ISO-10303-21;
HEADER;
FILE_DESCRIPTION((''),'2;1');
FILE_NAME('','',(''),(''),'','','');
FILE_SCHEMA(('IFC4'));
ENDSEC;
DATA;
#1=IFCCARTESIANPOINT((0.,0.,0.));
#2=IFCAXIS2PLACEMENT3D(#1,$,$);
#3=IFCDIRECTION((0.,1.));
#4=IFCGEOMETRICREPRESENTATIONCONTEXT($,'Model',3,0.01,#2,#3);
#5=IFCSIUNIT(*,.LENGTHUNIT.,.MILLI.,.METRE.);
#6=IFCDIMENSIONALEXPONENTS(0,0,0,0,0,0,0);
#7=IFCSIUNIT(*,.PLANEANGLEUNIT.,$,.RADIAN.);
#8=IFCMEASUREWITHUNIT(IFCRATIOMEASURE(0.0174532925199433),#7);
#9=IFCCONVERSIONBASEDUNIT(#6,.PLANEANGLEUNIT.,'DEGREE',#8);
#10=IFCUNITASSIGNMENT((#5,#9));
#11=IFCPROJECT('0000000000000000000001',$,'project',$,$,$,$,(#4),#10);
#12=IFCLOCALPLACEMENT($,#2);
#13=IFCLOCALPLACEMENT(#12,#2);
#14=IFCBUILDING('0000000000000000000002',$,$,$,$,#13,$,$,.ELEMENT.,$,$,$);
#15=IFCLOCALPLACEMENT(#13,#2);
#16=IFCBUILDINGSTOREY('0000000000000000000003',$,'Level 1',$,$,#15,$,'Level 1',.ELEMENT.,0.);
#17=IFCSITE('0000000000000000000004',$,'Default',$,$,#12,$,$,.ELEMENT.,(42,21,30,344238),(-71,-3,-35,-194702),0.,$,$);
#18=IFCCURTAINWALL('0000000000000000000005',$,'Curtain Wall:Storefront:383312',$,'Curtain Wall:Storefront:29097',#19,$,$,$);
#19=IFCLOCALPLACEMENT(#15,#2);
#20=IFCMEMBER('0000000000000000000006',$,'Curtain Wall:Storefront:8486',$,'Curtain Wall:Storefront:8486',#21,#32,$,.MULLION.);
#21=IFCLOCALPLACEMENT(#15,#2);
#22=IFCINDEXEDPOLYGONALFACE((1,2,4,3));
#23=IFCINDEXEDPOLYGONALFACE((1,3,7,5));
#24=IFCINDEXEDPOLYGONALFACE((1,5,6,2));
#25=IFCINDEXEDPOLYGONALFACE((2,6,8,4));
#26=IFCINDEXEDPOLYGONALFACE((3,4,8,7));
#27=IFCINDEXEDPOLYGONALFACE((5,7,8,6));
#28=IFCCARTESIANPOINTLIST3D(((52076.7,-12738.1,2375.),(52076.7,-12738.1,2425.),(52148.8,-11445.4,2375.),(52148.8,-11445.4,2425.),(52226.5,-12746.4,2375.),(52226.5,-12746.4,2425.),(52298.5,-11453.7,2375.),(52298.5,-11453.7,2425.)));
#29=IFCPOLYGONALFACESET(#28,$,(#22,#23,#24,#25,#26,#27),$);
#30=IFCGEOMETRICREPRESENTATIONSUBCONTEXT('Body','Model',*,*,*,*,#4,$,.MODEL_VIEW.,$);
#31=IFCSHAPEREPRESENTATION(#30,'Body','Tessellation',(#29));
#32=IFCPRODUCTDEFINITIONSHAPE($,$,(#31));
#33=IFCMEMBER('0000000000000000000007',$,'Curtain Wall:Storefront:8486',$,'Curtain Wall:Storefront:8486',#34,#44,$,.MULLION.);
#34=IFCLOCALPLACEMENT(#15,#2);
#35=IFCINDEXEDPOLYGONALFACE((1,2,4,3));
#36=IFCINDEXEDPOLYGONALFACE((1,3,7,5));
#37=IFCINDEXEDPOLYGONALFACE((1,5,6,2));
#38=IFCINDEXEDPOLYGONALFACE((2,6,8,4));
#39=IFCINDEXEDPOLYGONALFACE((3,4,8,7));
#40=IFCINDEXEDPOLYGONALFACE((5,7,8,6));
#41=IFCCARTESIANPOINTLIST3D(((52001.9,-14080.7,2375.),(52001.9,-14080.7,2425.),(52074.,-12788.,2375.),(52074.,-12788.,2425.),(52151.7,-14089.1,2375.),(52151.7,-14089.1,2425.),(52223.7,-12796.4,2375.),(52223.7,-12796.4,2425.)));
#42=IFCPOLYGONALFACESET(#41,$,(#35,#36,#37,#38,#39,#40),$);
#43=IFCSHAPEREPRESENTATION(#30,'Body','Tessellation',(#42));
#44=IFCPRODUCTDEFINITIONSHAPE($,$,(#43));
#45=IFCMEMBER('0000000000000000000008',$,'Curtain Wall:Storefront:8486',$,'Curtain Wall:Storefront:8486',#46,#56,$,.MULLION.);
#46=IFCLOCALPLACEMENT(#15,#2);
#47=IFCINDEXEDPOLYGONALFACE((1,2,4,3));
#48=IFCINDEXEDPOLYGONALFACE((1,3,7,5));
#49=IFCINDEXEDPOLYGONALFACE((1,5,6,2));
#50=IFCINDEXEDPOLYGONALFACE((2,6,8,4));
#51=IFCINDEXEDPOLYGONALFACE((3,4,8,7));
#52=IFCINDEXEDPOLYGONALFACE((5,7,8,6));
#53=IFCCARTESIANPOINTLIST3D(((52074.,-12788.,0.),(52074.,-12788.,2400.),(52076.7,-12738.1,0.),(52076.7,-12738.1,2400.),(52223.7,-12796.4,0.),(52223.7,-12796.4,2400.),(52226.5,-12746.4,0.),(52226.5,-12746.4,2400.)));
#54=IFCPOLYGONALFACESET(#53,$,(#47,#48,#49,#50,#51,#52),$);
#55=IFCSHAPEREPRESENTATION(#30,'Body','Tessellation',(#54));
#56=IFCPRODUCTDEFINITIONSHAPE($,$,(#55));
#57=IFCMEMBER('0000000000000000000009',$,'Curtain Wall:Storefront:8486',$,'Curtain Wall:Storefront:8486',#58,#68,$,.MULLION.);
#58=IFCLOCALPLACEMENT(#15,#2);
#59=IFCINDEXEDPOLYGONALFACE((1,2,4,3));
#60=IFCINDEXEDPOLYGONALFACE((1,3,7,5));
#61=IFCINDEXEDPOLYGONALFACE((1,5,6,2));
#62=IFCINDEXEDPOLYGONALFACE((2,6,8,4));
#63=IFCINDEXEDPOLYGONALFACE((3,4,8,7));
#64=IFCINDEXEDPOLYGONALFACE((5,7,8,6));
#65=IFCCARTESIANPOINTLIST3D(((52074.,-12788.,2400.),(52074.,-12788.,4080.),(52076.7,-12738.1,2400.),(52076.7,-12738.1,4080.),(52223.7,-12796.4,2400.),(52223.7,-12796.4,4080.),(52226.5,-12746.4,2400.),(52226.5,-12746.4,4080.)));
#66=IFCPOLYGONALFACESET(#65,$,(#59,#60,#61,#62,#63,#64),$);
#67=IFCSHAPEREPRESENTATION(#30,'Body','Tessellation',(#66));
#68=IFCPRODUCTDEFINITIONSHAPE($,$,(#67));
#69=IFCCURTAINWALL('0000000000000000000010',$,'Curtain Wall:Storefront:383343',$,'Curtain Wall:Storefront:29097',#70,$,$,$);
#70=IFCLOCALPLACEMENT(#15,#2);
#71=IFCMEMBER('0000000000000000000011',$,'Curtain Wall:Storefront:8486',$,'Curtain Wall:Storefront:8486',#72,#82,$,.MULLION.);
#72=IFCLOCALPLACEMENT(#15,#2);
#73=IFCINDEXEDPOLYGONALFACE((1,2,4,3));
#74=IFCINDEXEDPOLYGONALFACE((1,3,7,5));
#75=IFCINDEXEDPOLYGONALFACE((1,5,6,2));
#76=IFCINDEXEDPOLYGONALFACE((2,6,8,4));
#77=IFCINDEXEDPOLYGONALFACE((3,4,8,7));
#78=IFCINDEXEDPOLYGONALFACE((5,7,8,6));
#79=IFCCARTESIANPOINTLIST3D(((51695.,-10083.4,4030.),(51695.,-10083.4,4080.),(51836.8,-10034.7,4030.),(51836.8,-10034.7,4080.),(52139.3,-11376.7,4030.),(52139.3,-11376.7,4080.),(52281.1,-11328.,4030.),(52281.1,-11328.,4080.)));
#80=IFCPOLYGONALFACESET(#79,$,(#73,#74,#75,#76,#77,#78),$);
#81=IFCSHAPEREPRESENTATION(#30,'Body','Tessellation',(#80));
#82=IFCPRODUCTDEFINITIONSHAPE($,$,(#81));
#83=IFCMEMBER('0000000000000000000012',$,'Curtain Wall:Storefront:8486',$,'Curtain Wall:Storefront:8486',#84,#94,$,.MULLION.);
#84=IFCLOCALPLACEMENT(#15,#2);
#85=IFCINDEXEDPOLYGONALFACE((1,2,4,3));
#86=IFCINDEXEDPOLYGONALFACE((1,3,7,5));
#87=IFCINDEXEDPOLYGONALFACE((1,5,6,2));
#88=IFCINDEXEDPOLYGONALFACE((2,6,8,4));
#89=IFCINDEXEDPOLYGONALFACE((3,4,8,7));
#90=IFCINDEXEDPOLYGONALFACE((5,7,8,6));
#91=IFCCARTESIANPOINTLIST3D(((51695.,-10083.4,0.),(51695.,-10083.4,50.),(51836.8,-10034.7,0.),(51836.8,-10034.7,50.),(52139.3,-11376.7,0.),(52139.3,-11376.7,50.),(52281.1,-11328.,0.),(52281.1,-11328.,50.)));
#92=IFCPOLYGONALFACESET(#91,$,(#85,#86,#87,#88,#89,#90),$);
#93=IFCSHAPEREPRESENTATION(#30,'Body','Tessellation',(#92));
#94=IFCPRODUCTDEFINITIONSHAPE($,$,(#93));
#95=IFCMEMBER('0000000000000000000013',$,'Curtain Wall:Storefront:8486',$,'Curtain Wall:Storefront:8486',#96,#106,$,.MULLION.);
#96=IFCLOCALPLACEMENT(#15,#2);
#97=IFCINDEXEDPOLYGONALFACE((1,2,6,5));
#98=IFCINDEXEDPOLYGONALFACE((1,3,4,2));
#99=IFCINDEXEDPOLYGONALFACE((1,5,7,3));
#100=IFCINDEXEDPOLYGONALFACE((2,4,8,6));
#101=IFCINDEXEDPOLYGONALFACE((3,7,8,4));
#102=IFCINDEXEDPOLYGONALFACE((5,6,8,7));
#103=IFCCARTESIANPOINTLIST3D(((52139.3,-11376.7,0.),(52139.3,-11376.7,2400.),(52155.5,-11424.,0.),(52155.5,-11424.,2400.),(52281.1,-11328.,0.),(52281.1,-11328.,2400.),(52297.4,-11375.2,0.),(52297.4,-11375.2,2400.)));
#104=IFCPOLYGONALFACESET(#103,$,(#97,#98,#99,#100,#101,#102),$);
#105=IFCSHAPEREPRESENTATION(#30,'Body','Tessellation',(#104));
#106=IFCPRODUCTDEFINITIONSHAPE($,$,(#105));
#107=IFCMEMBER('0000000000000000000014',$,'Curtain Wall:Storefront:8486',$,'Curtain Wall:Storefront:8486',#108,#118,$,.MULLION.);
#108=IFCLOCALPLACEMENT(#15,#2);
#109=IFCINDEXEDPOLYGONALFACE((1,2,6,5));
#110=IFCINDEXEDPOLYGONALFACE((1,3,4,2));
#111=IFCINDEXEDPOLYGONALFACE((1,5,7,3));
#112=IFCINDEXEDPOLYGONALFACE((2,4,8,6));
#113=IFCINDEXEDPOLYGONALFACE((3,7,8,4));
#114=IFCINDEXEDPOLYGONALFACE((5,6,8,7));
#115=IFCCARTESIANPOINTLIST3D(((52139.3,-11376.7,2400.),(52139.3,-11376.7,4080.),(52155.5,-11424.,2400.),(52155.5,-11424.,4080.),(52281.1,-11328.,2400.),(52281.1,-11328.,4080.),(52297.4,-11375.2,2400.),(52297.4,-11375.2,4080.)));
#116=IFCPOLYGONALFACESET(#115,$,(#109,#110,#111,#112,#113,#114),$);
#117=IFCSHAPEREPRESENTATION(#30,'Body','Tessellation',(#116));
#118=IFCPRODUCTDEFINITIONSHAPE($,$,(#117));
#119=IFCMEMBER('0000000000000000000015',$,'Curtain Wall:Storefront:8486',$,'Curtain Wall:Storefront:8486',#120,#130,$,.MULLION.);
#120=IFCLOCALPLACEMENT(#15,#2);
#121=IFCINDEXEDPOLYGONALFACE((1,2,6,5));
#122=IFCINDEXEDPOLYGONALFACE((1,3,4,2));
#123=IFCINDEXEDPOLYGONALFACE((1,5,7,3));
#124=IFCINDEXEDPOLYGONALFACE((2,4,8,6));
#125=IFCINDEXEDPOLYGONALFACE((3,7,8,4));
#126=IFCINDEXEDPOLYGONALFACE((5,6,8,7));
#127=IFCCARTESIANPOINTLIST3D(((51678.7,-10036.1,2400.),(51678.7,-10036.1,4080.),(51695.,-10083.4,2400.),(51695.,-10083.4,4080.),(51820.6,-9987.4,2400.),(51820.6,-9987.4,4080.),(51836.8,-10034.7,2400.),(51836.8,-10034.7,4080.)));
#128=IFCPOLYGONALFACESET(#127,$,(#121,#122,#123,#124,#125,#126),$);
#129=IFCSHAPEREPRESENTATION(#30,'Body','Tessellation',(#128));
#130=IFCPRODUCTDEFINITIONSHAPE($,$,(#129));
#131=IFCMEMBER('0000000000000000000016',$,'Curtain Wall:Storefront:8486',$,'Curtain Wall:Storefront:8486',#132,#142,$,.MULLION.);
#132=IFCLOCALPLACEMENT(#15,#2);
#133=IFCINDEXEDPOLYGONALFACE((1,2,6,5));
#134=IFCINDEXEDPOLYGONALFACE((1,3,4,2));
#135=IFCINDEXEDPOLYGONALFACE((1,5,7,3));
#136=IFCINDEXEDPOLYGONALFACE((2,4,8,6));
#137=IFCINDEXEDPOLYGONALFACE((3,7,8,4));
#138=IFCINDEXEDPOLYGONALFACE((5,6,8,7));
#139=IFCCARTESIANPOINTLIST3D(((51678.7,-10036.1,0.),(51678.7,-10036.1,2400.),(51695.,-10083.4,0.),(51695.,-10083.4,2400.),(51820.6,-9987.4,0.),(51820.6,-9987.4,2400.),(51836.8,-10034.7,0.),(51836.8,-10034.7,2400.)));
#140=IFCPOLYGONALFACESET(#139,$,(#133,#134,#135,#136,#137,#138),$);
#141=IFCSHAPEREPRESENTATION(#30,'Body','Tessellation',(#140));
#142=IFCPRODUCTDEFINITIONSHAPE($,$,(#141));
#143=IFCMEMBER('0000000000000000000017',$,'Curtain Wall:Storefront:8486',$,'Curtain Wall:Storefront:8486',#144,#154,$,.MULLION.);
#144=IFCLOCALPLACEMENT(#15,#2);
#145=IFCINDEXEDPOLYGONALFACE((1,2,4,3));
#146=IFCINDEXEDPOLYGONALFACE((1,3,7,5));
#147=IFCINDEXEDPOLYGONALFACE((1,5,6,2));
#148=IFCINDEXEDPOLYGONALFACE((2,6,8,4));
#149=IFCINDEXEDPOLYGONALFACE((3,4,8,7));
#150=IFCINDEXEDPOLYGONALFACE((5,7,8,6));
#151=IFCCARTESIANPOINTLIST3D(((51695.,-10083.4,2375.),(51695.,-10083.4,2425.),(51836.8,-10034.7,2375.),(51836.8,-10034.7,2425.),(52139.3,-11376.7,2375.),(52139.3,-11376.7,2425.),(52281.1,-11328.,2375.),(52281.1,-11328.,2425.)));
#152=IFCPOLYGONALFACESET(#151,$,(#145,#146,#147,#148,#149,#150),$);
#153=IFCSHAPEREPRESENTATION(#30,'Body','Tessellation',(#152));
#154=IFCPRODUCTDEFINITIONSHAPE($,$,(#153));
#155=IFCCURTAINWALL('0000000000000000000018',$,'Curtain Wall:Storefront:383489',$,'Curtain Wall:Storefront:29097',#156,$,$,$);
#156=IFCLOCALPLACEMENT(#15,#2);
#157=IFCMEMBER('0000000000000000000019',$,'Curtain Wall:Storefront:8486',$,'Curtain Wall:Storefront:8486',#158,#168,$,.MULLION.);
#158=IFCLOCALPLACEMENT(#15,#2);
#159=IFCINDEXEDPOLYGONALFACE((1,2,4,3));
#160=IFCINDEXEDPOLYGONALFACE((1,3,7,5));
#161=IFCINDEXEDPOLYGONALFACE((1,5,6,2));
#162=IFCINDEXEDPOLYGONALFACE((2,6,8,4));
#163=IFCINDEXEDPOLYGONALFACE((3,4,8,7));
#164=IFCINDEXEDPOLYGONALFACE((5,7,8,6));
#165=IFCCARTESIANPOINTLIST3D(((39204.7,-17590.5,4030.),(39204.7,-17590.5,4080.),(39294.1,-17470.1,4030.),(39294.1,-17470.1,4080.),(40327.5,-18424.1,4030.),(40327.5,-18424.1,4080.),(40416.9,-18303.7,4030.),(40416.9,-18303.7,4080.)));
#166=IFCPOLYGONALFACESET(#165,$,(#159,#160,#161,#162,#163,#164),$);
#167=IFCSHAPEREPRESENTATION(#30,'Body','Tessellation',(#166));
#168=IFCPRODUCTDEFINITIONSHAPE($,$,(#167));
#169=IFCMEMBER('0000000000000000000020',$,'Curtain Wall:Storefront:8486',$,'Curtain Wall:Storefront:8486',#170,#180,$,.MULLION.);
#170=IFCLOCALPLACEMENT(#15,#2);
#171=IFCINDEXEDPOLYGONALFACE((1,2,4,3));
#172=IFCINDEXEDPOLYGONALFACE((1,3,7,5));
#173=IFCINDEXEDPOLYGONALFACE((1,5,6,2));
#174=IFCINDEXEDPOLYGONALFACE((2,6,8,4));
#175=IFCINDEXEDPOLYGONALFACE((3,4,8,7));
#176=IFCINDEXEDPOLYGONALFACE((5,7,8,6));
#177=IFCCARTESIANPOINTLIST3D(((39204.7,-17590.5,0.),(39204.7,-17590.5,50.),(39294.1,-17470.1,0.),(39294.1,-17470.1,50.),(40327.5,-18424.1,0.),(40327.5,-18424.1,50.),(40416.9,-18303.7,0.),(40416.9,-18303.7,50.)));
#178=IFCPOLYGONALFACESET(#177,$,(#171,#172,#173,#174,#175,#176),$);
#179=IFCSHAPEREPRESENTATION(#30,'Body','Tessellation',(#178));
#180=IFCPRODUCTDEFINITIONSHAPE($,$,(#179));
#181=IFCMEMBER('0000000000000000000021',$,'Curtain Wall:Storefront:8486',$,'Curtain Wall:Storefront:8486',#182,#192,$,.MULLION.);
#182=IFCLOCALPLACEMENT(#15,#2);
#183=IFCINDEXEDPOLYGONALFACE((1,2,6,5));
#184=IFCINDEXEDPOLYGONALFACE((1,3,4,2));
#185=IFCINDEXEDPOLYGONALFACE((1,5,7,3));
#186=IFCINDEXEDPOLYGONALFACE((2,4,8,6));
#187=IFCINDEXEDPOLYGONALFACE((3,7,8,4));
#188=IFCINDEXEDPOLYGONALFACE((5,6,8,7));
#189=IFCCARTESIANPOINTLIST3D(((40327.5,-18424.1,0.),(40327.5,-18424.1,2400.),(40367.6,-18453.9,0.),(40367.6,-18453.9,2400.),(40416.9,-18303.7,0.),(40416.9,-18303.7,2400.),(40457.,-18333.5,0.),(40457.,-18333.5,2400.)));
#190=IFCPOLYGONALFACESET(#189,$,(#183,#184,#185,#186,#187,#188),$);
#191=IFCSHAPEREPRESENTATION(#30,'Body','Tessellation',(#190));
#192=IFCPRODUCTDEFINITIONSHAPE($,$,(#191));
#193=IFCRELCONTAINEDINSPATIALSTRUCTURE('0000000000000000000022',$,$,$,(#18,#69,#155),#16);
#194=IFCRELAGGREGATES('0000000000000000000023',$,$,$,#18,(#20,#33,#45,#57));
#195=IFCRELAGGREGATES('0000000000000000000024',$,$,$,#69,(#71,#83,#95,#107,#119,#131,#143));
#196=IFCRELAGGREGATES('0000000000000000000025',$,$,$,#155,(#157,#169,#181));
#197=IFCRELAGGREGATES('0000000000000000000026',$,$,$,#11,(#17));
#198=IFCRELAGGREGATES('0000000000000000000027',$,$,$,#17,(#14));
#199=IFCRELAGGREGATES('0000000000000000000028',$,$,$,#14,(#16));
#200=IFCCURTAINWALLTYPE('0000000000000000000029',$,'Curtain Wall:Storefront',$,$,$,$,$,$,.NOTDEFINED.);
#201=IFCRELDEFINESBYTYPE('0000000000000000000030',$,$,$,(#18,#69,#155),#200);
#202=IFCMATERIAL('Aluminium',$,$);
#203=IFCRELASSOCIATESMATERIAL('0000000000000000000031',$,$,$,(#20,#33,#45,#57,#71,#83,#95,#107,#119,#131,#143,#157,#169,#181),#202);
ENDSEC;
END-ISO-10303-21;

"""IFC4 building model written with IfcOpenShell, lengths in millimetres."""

from ifc_helpers import new_model, entity, si_unit, converted_unit, direction, frame, frame_2d, origin, origin_2d_with_axis, place, context, subcontext, project, spatial, rectangle, extrude, material, type_object, element, aggregate, save


model = new_model("IFC4")

# Units and contexts
model_context = context("Model", 3, precision=0.01, world=origin(), true_north=direction((0.0, 1.0)))
body_context = subcontext(model_context, "Body", "Model", "MODEL_VIEW")
ifc_project = project(units=[si_unit("LENGTHUNIT", "METRE", prefix="MILLI"), converted_unit("PLANEANGLEUNIT", "DEGREE", entity("IfcRatioMeasure", 0.0174532925199433), si_unit("PLANEANGLEUNIT", "RADIAN"), dimensions=[0, 0, 0, 0, 0, 0, 0])], contexts=[model_context])

# Site, building, storey
site_placement = place(None, origin())
site = spatial("IfcSite", under=ifc_project, at=site_placement, Name="Default", CompositionType="ELEMENT", RefLatitude=(42, 21, 30, 344238), RefLongitude=(-71, -3, -35, -194702), RefElevation=0.0)
building_placement = place(site_placement, origin())
building = spatial("IfcBuilding", under=site, at=building_placement, CompositionType="ELEMENT")
storey_placement = place(building_placement, origin())
storey = spatial("IfcBuildingStorey", under=building, at=storey_placement, Name="Level 1", LongName="Level 1", CompositionType="ELEMENT", Elevation=0.0)

# Curtain walls, members
curtain_wall_type = type_object("IfcCurtainWallType", Name="Curtain Wall:Storefront", PredefinedType="NOTDEFINED")
ifc_material = material(Name="Aluminium")
curtain_wall_1_placement = place(storey_placement, origin())
curtain_wall_1 = element("IfcCurtainWall", 1, at=curtain_wall_1_placement, inside=storey, type_object=curtain_wall_type, Name="Curtain Wall:Storefront:383312", ObjectType="Curtain Wall:Storefront:29097")
member_1_placement = place(curtain_wall_1_placement, origin())
member_1 = element("IfcMember", 2, at=member_1_placement, material=ifc_material, Name="Curtain Wall:Storefront:8486", ObjectType="Curtain Wall:Storefront:8486", PredefinedType="MULLION", context=body_context, shape_type="SweptSolid", body=[
    extrude(rectangle(XDim=50.0, YDim=150.0, at=origin_2d_with_axis()), frame((52151.6, -12742.3, 2400.0), z_axis=(0.055635, 0.998451, 0.0), x_axis=(0.0, 0.0, -1.0)), (0.0, 0.0, 1.0), 1294.7),
])
member_2_placement = place(curtain_wall_1_placement, origin())
member_2 = element("IfcMember", 3, at=member_2_placement, material=ifc_material, Name="Curtain Wall:Storefront:8486", ObjectType="Curtain Wall:Storefront:8486", PredefinedType="MULLION", context=body_context, shape_type="SweptSolid", body=[
    extrude(rectangle(XDim=50.0, YDim=150.0, at=origin_2d_with_axis()), frame((52076.8, -14084.9, 2400.0), z_axis=(0.055635, 0.998451, 0.0), x_axis=(0.0, 0.0, -1.0)), (0.0, 0.0, 1.0), 1294.7),
])
member_3_placement = place(curtain_wall_1_placement, origin())
member_3 = element("IfcMember", 4, at=member_3_placement, material=ifc_material, Name="Curtain Wall:Storefront:8486", ObjectType="Curtain Wall:Storefront:8486", PredefinedType="MULLION", context=body_context, shape_type="SweptSolid", body=[
    extrude(rectangle(XDim=150.0, YDim=50.0, at=origin_2d_with_axis()), frame((52150.2, -12767.2, 0.0), z_axis=(0.0, 0.0, 1.0), x_axis=(0.998451, -0.055635, 0.0)), (0.0, 0.0, 1.0), 2400.0),
])
member_4_placement = place(curtain_wall_1_placement, origin())
member_4 = element("IfcMember", 5, at=member_4_placement, material=ifc_material, Name="Curtain Wall:Storefront:8486", ObjectType="Curtain Wall:Storefront:8486", PredefinedType="MULLION", context=body_context, shape_type="SweptSolid", body=[
    extrude(rectangle(XDim=150.0, YDim=50.0, at=origin_2d_with_axis()), frame((52150.2, -12767.2, 2400.0), z_axis=(0.0, 0.0, 1.0), x_axis=(0.998451, -0.055635, 0.0)), (0.0, 0.0, 1.0), 1680.0),
])
aggregate(curtain_wall_1, [member_1, member_2, member_3, member_4])
curtain_wall_2_placement = place(storey_placement, origin())
curtain_wall_2 = element("IfcCurtainWall", 6, at=curtain_wall_2_placement, inside=storey, type_object=curtain_wall_type, Name="Curtain Wall:Storefront:383343", ObjectType="Curtain Wall:Storefront:29097")
member_5_placement = place(curtain_wall_2_placement, origin())
member_5 = element("IfcMember", 7, at=member_5_placement, material=ifc_material, Name="Curtain Wall:Storefront:8486", ObjectType="Curtain Wall:Storefront:8486", PredefinedType="MULLION", context=body_context, shape_type="SweptSolid", body=[
    extrude(rectangle(XDim=50.0, YDim=150.0, at=frame_2d((0.0, 0.0), x_axis=(1.0, 0.0))), frame((52210.2, -11352.3, 4055.0), z_axis=(-0.324896, 0.94575, 0.0), x_axis=(0.0, 0.0, -1.0)), (0.0, 0.0, 1.0), 1367.5),
])
member_6_placement = place(curtain_wall_2_placement, origin())
member_6 = element("IfcMember", 8, at=member_6_placement, material=ifc_material, Name="Curtain Wall:Storefront:8486", ObjectType="Curtain Wall:Storefront:8486", PredefinedType="MULLION", context=body_context, shape_type="SweptSolid", body=[
    extrude(rectangle(XDim=50.0, YDim=150.0, at=origin_2d_with_axis()), frame((51765.9, -10059.1, 25.0), z_axis=(0.324896, -0.94575, 0.0), x_axis=(0.0, 0.0, -1.0)), (0.0, 0.0, 1.0), 1367.5),
])
member_7_placement = place(curtain_wall_2_placement, origin())
member_7 = element("IfcMember", 9, at=member_7_placement, material=ifc_material, Name="Curtain Wall:Storefront:8486", ObjectType="Curtain Wall:Storefront:8486", PredefinedType="MULLION", context=body_context, shape_type="SweptSolid", body=[
    extrude(rectangle(XDim=150.0, YDim=50.0, at=origin_2d_with_axis()), frame((52218.3, -11376.0, 0.0), z_axis=(0.0, 0.0, 1.0), x_axis=(0.94575, 0.324896, 0.0)), (0.0, 0.0, 1.0), 2400.0),
])
member_8_placement = place(curtain_wall_2_placement, origin())
member_8 = element("IfcMember", 10, at=member_8_placement, material=ifc_material, Name="Curtain Wall:Storefront:8486", ObjectType="Curtain Wall:Storefront:8486", PredefinedType="MULLION", context=body_context, shape_type="SweptSolid", body=[
    extrude(rectangle(XDim=150.0, YDim=50.0, at=origin_2d_with_axis()), frame((52218.3, -11376.0, 2400.0), z_axis=(0.0, 0.0, 1.0), x_axis=(0.94575, 0.324896, 0.0)), (0.0, 0.0, 1.0), 1680.0),
])
member_9_placement = place(curtain_wall_2_placement, origin())
member_9 = element("IfcMember", 11, at=member_9_placement, material=ifc_material, Name="Curtain Wall:Storefront:8486", ObjectType="Curtain Wall:Storefront:8486", PredefinedType="MULLION", context=body_context, shape_type="SweptSolid", body=[
    extrude(rectangle(XDim=150.0, YDim=50.0, at=origin_2d_with_axis()), frame((51757.8, -10035.4, 4080.0), z_axis=(0.0, 0.0, -1.0), x_axis=(0.94575, 0.324896, 0.0)), (0.0, 0.0, 1.0), 1680.0),
])
member_10_placement = place(curtain_wall_2_placement, origin())
member_10 = element("IfcMember", 12, at=member_10_placement, material=ifc_material, Name="Curtain Wall:Storefront:8486", ObjectType="Curtain Wall:Storefront:8486", PredefinedType="MULLION", context=body_context, shape_type="SweptSolid", body=[
    extrude(rectangle(XDim=150.0, YDim=50.0, at=origin_2d_with_axis()), frame((51757.8, -10035.4, 2400.0), z_axis=(0.0, 0.0, -1.0), x_axis=(0.94575, 0.324896, 0.0)), (0.0, 0.0, 1.0), 2400.0),
])
member_11_placement = place(curtain_wall_2_placement, origin())
member_11 = element("IfcMember", 13, at=member_11_placement, material=ifc_material, Name="Curtain Wall:Storefront:8486", ObjectType="Curtain Wall:Storefront:8486", PredefinedType="MULLION", context=body_context, shape_type="SweptSolid", body=[
    extrude(rectangle(XDim=50.0, YDim=150.0, at=origin_2d_with_axis()), frame((52210.2, -11352.3, 2400.0), z_axis=(-0.324896, 0.94575, 0.0), x_axis=(0.0, 0.0, -1.0)), (0.0, 0.0, 1.0), 1367.5),
])
aggregate(curtain_wall_2, [member_5, member_6, member_7, member_8, member_9, member_10, member_11])
curtain_wall_3_placement = place(storey_placement, origin())
curtain_wall_3 = element("IfcCurtainWall", 14, at=curtain_wall_3_placement, inside=storey, type_object=curtain_wall_type, Name="Curtain Wall:Storefront:383489", ObjectType="Curtain Wall:Storefront:29097")
member_12_placement = place(curtain_wall_3_placement, origin())
member_12 = element("IfcMember", 15, at=member_12_placement, material=ifc_material, Name="Curtain Wall:Storefront:8486", ObjectType="Curtain Wall:Storefront:8486", PredefinedType="MULLION", context=body_context, shape_type="SweptSolid", body=[
    extrude(rectangle(XDim=50.0, YDim=150.0, at=frame_2d((0.0, 0.0), x_axis=(1.0, 0.0))), frame((40372.2, -18363.9, 4055.0), z_axis=(-0.80291, 0.5961, 0.0), x_axis=(0.0, 0.0, -1.0)), (0.0, 0.0, 1.0), 1398.4),
])
member_13_placement = place(curtain_wall_3_placement, origin())
member_13 = element("IfcMember", 16, at=member_13_placement, material=ifc_material, Name="Curtain Wall:Storefront:8486", ObjectType="Curtain Wall:Storefront:8486", PredefinedType="MULLION", context=body_context, shape_type="SweptSolid", body=[
    extrude(rectangle(XDim=50.0, YDim=150.0, at=frame_2d((0.0, 0.0), x_axis=(1.0, 0.0))), frame((39249.4, -17530.3, 25.0), z_axis=(0.80291, -0.5961, 0.0), x_axis=(0.0, 0.0, -1.0)), (0.0, 0.0, 1.0), 1398.4),
])
member_14_placement = place(curtain_wall_3_placement, origin())
member_14 = element("IfcMember", 17, at=member_14_placement, material=ifc_material, Name="Curtain Wall:Storefront:8486", ObjectType="Curtain Wall:Storefront:8486", PredefinedType="MULLION", context=body_context, shape_type="SweptSolid", body=[
    extrude(rectangle(XDim=50.0, YDim=150.0, at=origin_2d_with_axis()), frame((40392.3, -18378.8, 0.0), z_axis=(0.0, 0.0, 1.0), x_axis=(0.80291, -0.5961, 0.0)), (0.0, 0.0, 1.0), 2400.0),
])
aggregate(curtain_wall_3, [member_12, member_13, member_14])

save(model, "model.ifc")
